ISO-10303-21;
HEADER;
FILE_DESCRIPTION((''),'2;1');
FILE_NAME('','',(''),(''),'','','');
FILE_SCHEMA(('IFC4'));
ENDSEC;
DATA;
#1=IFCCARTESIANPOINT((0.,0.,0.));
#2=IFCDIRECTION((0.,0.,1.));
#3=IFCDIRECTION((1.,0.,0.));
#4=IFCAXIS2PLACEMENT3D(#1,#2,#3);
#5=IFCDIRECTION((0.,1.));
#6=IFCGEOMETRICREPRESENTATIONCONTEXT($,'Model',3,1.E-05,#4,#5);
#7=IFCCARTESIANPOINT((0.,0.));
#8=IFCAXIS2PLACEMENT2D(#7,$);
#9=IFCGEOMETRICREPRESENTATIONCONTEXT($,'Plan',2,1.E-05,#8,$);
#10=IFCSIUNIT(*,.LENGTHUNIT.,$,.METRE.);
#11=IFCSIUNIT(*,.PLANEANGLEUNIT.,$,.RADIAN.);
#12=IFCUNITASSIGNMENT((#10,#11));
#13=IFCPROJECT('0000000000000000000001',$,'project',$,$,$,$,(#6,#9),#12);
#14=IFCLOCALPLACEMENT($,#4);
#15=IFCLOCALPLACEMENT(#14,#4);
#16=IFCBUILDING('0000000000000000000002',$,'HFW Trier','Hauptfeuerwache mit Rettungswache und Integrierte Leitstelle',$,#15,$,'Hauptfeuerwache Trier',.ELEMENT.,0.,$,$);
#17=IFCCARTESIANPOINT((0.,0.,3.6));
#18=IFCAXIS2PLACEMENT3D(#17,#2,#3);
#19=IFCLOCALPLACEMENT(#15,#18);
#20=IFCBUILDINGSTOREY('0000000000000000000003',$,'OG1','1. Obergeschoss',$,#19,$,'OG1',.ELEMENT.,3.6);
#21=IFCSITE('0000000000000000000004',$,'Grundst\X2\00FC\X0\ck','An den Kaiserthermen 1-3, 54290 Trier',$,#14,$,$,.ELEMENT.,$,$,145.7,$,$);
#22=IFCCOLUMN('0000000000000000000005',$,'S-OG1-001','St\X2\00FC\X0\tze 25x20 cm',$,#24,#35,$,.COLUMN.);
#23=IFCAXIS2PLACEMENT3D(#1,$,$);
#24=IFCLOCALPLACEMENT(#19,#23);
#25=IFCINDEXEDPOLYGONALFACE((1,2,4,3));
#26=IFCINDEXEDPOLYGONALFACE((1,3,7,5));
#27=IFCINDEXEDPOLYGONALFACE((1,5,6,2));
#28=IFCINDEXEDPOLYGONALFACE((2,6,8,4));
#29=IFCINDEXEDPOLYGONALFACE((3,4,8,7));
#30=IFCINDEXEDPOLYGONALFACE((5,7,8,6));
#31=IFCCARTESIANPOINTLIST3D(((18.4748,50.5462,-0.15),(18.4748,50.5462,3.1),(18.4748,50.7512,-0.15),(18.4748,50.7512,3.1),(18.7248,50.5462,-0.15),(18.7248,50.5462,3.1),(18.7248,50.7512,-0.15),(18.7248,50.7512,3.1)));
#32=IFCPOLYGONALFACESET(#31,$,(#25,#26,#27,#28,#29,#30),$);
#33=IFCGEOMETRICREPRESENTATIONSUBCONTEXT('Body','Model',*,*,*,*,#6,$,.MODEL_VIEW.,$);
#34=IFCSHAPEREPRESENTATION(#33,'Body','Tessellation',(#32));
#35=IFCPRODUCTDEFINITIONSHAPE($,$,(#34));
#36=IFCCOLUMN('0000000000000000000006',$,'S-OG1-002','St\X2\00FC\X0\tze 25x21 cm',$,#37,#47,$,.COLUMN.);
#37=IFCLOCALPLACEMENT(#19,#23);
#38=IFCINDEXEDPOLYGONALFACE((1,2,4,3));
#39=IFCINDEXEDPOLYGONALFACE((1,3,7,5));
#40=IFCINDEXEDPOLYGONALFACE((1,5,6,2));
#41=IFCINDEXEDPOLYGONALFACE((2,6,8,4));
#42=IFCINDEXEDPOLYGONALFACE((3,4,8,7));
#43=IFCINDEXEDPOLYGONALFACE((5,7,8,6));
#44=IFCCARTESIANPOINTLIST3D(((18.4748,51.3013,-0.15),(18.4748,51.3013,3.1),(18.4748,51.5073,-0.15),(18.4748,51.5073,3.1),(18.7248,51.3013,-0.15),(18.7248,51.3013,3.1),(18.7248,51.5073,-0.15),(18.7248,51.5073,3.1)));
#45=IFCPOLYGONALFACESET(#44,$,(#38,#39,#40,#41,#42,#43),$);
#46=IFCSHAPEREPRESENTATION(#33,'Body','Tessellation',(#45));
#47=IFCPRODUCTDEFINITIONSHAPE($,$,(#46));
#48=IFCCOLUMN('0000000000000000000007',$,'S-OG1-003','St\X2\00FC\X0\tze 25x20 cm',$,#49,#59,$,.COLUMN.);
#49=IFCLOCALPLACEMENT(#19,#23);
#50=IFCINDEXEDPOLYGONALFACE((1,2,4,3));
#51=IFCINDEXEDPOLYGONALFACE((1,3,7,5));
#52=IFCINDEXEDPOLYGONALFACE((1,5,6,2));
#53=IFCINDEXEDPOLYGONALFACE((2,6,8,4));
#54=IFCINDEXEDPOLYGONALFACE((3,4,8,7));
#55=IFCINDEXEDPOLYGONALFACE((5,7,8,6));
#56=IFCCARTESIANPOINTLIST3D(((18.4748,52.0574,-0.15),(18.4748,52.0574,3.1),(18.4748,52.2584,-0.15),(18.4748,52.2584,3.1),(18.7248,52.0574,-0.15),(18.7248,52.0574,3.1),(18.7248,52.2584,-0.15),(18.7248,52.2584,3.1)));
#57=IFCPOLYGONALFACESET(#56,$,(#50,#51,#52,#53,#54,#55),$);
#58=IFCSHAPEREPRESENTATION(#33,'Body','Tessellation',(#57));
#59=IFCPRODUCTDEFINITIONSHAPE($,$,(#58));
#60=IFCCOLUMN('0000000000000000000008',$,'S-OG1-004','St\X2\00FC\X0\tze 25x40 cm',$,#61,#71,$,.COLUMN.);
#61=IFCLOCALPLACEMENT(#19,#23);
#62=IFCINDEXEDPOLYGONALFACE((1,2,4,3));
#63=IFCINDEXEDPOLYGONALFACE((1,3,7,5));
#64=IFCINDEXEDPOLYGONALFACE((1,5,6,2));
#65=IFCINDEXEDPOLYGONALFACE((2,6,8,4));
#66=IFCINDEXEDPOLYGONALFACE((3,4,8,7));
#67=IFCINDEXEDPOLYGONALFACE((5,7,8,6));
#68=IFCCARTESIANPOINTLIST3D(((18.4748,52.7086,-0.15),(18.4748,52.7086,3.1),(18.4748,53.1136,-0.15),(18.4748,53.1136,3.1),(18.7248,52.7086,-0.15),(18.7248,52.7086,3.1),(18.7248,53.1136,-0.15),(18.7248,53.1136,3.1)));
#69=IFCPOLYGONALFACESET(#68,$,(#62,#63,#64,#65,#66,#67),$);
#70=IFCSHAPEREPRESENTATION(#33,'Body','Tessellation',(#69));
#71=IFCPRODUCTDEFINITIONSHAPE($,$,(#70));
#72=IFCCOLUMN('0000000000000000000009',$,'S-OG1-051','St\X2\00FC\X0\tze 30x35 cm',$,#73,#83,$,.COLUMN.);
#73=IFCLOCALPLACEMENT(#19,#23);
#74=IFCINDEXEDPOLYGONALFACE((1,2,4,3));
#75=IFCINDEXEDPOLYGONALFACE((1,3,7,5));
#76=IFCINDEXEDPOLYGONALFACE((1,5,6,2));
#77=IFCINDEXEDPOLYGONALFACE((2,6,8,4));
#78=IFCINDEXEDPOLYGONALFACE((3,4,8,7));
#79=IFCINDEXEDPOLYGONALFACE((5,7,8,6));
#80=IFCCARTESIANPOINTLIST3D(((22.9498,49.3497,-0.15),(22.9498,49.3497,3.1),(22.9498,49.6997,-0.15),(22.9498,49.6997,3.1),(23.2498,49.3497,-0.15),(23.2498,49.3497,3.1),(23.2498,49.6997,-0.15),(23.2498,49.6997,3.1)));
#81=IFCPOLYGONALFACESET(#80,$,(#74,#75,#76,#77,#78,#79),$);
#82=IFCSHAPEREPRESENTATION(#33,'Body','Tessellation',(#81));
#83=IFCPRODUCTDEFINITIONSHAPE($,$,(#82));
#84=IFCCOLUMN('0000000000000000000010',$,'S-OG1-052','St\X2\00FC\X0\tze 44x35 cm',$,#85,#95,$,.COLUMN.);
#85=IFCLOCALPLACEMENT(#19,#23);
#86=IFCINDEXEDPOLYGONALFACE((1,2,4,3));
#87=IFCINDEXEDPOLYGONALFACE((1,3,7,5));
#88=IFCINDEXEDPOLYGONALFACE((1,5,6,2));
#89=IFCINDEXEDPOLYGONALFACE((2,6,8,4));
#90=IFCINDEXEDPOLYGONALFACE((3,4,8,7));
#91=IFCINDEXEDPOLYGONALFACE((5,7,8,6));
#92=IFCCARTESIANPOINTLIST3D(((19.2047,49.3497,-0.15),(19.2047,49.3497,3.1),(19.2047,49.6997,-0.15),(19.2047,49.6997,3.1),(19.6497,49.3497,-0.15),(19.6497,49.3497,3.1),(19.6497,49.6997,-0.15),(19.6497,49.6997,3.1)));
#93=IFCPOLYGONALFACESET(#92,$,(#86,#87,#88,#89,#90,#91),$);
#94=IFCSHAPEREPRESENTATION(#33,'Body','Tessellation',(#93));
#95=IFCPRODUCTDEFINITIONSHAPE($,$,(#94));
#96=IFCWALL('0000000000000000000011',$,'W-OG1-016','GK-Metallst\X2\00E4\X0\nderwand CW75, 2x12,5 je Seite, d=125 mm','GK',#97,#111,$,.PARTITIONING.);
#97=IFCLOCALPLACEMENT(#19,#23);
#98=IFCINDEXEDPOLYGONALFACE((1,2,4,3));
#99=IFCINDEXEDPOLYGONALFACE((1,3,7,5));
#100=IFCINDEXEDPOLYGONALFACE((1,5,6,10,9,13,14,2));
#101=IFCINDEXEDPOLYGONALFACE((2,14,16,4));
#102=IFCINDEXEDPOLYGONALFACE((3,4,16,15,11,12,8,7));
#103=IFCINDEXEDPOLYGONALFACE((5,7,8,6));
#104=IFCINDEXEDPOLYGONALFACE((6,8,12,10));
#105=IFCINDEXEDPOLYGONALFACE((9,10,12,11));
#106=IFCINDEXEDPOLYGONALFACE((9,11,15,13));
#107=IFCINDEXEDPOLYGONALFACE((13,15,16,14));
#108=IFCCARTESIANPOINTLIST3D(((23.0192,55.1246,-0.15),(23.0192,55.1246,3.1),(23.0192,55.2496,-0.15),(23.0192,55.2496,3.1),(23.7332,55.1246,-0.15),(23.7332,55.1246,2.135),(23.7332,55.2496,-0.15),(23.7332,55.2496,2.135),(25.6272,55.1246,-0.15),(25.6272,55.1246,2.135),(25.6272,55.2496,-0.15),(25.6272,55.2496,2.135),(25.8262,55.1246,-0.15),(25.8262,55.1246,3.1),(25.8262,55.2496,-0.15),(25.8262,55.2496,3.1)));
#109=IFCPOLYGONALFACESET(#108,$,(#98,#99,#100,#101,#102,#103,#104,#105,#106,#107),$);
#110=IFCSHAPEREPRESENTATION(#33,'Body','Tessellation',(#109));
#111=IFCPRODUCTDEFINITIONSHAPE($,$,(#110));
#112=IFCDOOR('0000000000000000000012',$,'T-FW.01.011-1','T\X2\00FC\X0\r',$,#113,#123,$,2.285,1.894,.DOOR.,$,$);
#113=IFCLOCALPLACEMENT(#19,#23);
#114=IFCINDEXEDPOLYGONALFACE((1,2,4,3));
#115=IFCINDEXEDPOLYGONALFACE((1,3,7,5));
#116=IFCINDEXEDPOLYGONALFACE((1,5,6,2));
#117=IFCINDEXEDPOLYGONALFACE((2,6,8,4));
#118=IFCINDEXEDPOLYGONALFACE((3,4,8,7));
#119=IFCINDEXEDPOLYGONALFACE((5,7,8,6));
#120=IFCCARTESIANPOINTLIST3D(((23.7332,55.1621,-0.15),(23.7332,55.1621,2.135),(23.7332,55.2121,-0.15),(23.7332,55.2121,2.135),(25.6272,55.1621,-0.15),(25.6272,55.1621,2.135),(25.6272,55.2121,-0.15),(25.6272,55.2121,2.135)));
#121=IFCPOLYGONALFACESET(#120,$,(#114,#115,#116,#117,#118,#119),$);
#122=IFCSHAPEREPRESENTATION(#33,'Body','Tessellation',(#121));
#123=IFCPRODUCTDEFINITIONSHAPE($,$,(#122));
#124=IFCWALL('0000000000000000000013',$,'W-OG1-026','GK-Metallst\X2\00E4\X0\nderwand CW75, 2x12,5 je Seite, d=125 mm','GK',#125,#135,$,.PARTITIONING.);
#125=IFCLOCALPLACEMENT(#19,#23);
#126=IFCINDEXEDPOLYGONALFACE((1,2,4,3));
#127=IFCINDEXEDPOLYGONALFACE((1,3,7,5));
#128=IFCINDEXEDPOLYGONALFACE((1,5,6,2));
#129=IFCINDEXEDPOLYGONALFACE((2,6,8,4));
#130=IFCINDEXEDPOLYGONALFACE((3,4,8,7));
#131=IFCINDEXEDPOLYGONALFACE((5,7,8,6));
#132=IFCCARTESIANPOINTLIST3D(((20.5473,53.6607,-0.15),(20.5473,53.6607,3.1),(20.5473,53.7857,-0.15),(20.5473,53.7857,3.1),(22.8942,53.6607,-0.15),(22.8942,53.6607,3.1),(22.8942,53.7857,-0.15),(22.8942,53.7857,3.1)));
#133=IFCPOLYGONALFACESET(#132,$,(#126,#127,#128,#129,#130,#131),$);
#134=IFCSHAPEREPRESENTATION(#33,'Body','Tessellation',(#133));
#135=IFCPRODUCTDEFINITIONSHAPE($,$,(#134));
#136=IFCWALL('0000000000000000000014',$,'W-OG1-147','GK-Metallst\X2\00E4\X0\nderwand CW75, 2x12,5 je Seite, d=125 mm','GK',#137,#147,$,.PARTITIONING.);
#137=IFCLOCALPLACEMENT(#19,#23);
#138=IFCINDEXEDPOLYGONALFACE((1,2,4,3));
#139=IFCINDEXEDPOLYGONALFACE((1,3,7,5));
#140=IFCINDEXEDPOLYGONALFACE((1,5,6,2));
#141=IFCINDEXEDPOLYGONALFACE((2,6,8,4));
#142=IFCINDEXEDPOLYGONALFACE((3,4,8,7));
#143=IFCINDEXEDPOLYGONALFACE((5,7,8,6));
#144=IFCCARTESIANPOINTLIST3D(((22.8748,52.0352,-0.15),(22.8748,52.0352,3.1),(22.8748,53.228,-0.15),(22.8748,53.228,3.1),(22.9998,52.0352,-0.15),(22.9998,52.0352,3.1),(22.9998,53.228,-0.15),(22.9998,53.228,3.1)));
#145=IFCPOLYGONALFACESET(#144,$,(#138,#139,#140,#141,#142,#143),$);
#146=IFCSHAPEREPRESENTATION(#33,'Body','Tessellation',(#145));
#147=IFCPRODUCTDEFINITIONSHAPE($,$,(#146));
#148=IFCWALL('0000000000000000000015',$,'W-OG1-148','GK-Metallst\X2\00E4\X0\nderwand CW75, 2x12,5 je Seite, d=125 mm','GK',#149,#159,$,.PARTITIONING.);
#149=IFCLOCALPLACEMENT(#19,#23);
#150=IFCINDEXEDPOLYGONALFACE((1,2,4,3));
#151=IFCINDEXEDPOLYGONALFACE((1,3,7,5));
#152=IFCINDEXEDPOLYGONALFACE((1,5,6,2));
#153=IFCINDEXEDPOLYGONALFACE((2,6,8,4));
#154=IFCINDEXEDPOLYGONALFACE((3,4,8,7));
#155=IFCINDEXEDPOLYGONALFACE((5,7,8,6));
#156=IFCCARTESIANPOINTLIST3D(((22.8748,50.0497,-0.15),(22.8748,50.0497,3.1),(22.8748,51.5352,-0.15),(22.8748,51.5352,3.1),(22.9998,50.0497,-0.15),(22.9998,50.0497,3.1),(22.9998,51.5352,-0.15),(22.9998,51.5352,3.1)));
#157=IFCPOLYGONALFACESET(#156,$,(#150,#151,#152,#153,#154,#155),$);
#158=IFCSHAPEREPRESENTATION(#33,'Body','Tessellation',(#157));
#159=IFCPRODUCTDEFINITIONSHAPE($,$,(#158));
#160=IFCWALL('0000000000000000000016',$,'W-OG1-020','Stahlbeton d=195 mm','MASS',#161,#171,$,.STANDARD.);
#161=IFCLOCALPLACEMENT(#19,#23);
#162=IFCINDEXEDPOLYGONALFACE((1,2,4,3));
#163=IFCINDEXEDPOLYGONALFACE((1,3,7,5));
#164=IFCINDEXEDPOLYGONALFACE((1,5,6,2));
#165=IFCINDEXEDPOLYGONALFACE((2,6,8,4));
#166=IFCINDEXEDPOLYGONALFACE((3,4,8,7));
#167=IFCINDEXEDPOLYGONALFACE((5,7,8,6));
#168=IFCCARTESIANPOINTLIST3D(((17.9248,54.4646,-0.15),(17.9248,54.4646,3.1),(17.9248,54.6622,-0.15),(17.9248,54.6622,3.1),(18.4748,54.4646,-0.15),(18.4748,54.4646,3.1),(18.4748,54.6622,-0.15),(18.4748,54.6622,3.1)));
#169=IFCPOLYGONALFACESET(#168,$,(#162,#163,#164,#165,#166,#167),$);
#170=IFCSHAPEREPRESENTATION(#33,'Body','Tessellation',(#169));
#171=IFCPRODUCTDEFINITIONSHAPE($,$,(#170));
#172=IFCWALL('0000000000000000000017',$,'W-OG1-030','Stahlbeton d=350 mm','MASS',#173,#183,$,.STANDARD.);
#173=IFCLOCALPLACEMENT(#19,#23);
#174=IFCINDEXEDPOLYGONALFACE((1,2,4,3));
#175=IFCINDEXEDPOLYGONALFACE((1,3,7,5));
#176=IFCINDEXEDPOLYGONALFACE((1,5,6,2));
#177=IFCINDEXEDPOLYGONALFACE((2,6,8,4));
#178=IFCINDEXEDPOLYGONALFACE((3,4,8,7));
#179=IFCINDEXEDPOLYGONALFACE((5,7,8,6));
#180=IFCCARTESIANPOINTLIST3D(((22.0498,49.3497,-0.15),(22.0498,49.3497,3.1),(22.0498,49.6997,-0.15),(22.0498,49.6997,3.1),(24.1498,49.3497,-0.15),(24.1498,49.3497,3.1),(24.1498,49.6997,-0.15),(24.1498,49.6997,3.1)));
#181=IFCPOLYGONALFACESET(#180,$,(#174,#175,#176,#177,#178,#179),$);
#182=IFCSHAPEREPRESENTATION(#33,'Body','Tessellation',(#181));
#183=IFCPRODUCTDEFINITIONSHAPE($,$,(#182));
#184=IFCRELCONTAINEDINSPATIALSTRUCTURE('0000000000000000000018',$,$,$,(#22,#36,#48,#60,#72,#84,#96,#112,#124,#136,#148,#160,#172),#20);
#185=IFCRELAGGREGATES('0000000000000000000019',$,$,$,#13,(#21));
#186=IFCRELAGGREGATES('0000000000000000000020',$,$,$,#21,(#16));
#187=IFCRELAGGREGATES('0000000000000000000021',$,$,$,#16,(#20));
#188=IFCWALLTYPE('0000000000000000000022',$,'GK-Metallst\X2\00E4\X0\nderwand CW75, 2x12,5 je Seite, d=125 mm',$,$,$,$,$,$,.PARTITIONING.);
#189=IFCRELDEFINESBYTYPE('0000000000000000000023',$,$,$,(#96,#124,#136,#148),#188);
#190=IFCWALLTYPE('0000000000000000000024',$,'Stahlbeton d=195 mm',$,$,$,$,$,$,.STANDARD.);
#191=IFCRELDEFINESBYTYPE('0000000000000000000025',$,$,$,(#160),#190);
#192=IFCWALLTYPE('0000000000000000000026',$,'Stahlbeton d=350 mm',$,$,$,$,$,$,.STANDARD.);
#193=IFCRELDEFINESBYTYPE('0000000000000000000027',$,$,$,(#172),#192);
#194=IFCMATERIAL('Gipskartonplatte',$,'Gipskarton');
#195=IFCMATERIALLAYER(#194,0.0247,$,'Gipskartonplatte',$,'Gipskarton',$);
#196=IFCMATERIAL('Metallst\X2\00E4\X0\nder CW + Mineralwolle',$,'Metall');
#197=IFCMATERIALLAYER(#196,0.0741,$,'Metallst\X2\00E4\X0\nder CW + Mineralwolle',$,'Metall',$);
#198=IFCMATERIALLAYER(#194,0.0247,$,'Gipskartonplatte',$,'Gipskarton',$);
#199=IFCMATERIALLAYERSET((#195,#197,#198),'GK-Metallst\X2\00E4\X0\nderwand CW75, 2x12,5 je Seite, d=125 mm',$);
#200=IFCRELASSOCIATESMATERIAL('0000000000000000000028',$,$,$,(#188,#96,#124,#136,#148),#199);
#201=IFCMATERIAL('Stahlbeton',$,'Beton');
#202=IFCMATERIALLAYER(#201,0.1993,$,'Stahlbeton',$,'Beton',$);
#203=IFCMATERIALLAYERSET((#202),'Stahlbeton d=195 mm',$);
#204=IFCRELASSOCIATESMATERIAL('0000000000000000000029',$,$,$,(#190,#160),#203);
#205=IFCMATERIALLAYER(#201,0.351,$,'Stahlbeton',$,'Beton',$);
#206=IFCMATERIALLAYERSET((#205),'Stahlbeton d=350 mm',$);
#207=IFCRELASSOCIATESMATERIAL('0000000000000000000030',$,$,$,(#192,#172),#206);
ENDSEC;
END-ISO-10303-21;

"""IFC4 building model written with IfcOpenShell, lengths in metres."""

from ifc_helpers import new_model, si_unit, direction, frame, frame_2d, origin_with_axes, origin_2d, place, context, subcontext, project, spatial, rectangle, extrude, material, layer, layer_set, layer_usage, type_object, element, fill, save


model = new_model("IFC4")

# Units and contexts
model_context = context("Model", 3, precision=1e-05, world=origin_with_axes(), true_north=direction((0.0, 1.0)))
plan_context = context("Plan", 2, precision=1e-05, world=origin_2d())
body_context = subcontext(model_context, "Body", "Model", "MODEL_VIEW")
ifc_project = project(units=[si_unit("LENGTHUNIT", "METRE"), si_unit("PLANEANGLEUNIT", "RADIAN")], contexts=[model_context, plan_context])

# Site, building, storey
site_placement = place(None, origin_with_axes())
site = spatial("IfcSite", under=ifc_project, at=site_placement, Name="Grundstück", Description="An den Kaiserthermen 1-3, 54290 Trier", CompositionType="ELEMENT", RefElevation=145.7)
building_placement = place(site_placement, origin_with_axes())
building = spatial("IfcBuilding", under=site, at=building_placement, Name="HFW Trier", Description="Hauptfeuerwache mit Rettungswache und Integrierte Leitstelle", LongName="Hauptfeuerwache Trier", CompositionType="ELEMENT", ElevationOfRefHeight=0.0)
storey_placement = place(building_placement, frame((0.0, 0.0, 3.6), z_axis=(0.0, 0.0, 1.0), x_axis=(1.0, 0.0, 0.0)))
storey = spatial("IfcBuildingStorey", under=building, at=storey_placement, Name="OG1", Description="1. Obergeschoss", LongName="OG1", CompositionType="ELEMENT", Elevation=3.6)

# Columns
column_1_placement = place(storey_placement, frame((18.4748, 50.6487, -0.15), z_axis=(0.0, 0.0, 1.0), x_axis=(1.0, 0.0, 0.0)))
element("IfcColumn", 1, at=column_1_placement, inside=storey, Name="S-OG1-001", Description="Stütze 25x20 cm", PredefinedType="COLUMN", context=body_context, shape_type="SweptSolid", body=[
    extrude(rectangle(XDim=0.25, YDim=0.205, at=frame_2d((0.125, 0.0))), origin_with_axes(), (0.0, 0.0, 1.0), 3.25),
])
column_2_placement = place(storey_placement, frame((18.4748, 51.4043, -0.15), z_axis=(0.0, 0.0, 1.0), x_axis=(1.0, 0.0, 0.0)))
element("IfcColumn", 2, at=column_2_placement, inside=storey, Name="S-OG1-002", Description="Stütze 25x21 cm", PredefinedType="COLUMN", context=body_context, shape_type="SweptSolid", body=[
    extrude(rectangle(XDim=0.25, YDim=0.206, at=frame_2d((0.125, 0.0))), origin_with_axes(), (0.0, 0.0, 1.0), 3.25),
])
column_3_placement = place(storey_placement, frame((18.4748, 52.1579, -0.15), z_axis=(0.0, 0.0, 1.0), x_axis=(1.0, 0.0, 0.0)))
element("IfcColumn", 3, at=column_3_placement, inside=storey, Name="S-OG1-003", Description="Stütze 25x20 cm", PredefinedType="COLUMN", context=body_context, shape_type="SweptSolid", body=[
    extrude(rectangle(XDim=0.25, YDim=0.201, at=frame_2d((0.125, 0.0))), origin_with_axes(), (0.0, 0.0, 1.0), 3.25),
])
column_4_placement = place(storey_placement, frame((18.4748, 52.9111, -0.15), z_axis=(0.0, 0.0, 1.0), x_axis=(1.0, 0.0, 0.0)))
element("IfcColumn", 4, at=column_4_placement, inside=storey, Name="S-OG1-004", Description="Stütze 25x40 cm", PredefinedType="COLUMN", context=body_context, shape_type="SweptSolid", body=[
    extrude(rectangle(XDim=0.25, YDim=0.405, at=frame_2d((0.125, 0.0))), origin_with_axes(), (0.0, 0.0, 1.0), 3.25),
])
column_5_placement = place(storey_placement, frame((22.9498, 49.5247, -0.15), z_axis=(0.0, 0.0, 1.0), x_axis=(1.0, 0.0, 0.0)))
element("IfcColumn", 5, at=column_5_placement, inside=storey, Name="S-OG1-051", Description="Stütze 30x35 cm", PredefinedType="COLUMN", context=body_context, shape_type="SweptSolid", body=[
    extrude(rectangle(XDim=0.3, YDim=0.35, at=frame_2d((0.15, 0.0))), origin_with_axes(), (0.0, 0.0, 1.0), 3.25),
])
column_6_placement = place(storey_placement, frame((19.2047, 49.5247, -0.15), z_axis=(0.0, 0.0, 1.0), x_axis=(1.0, 0.0, 0.0)))
element("IfcColumn", 6, at=column_6_placement, inside=storey, Name="S-OG1-052", Description="Stütze 44x35 cm", PredefinedType="COLUMN", context=body_context, shape_type="SweptSolid", body=[
    extrude(rectangle(XDim=0.445, YDim=0.35, at=frame_2d((0.2225, 0.0))), origin_with_axes(), (0.0, 0.0, 1.0), 3.25),
])

# Wall, opening, door
ifc_material_1 = material(Name="Gipskartonplatte", Category="Gipskarton")
ifc_layer_1 = layer(ifc_material_1, 0.0247, Name="Gipskartonplatte", Category="Gipskarton")
ifc_material_2 = material(Name="Metallständer CW + Mineralwolle", Category="Metall")
ifc_layer_2 = layer(ifc_material_2, 0.0741, Name="Metallständer CW + Mineralwolle", Category="Metall")
ifc_layer_3 = layer(ifc_material_1, 0.0247, Name="Gipskartonplatte", Category="Gipskarton")
ifc_layer_set_1 = layer_set([ifc_layer_1, ifc_layer_2, ifc_layer_3], Name="GK-Metallständerwand CW75, 2x12,5 je Seite, d=125 mm")
ifc_layer_usage_1 = layer_usage(ifc_layer_set_1, "AXIS2", "POSITIVE", -0.0625)
wall_type_1 = type_object("IfcWallType", Name="GK-Metallständerwand CW75, 2x12,5 je Seite, d=125 mm", PredefinedType="PARTITIONING", material=ifc_layer_set_1)
wall_1_placement = place(storey_placement, frame((23.0192, 55.1871, -0.15), z_axis=(0.0, 0.0, 1.0), x_axis=(1.0, 0.0, 0.0)))
wall_1 = element("IfcWall", 7, at=wall_1_placement, inside=storey, type_object=wall_type_1, material=ifc_layer_usage_1, Name="W-OG1-016", Description="GK-Metallständerwand CW75, 2x12,5 je Seite, d=125 mm", ObjectType="GK", PredefinedType="PARTITIONING", context=body_context, shape_type="SweptSolid", body=[
    extrude(rectangle(XDim=2.807, YDim=0.125, at=frame_2d((1.4035, 0.0))), origin_with_axes(), (0.0, 0.0, 1.0), 3.25),
])
opening_1_placement = place(wall_1_placement, frame((0.714, 0.0, 0.0), z_axis=(0.0, 0.0, 1.0), x_axis=(1.0, 0.0, 0.0)))
opening_1 = element("IfcOpeningElement", 8, at=opening_1_placement, cuts=wall_1, PredefinedType="OPENING", context=body_context, shape_type="SweptSolid", body=[
    extrude(rectangle(XDim=1.894, YDim=0.225, at=frame_2d((0.947, 0.0))), origin_with_axes(), (0.0, 0.0, 1.0), 2.285),
])
door_1_placement = place(wall_1_placement, frame((0.714, 0.0, 0.0), z_axis=(0.0, 0.0, 1.0), x_axis=(1.0, 0.0, 0.0)))
door_1 = element("IfcDoor", 9, at=door_1_placement, inside=storey, Name="T-FW.01.011-1", Description="Tür", OverallHeight=2.285, OverallWidth=1.894, PredefinedType="DOOR", context=body_context, shape_type="SweptSolid", body=[
    extrude(rectangle(XDim=1.894, YDim=0.05, at=frame_2d((0.947, 0.0))), origin_with_axes(), (0.0, 0.0, 1.0), 2.285),
])
fill(opening_1, door_1)

# Walls
ifc_layer_usage_2 = layer_usage(ifc_layer_set_1, "AXIS2", "POSITIVE", -0.0625)
wall_2_placement = place(storey_placement, frame((20.5473, 53.7232, -0.15), z_axis=(0.0, 0.0, 1.0), x_axis=(1.0, 0.0, 0.0)))
element("IfcWall", 10, at=wall_2_placement, inside=storey, type_object=wall_type_1, material=ifc_layer_usage_2, Name="W-OG1-026", Description="GK-Metallständerwand CW75, 2x12,5 je Seite, d=125 mm", ObjectType="GK", PredefinedType="PARTITIONING", context=body_context, shape_type="SweptSolid", body=[
    extrude(rectangle(XDim=2.3469, YDim=0.125, at=frame_2d((1.1735, 0.0))), origin_with_axes(), (0.0, 0.0, 1.0), 3.25),
])
ifc_layer_usage_3 = layer_usage(ifc_layer_set_1, "AXIS2", "POSITIVE", -0.0625)
wall_3_placement = place(storey_placement, frame((22.9373, 53.228, -0.15), z_axis=(0.0, 0.0, 1.0), x_axis=(0.0, -1.0, 0.0)))
element("IfcWall", 11, at=wall_3_placement, inside=storey, type_object=wall_type_1, material=ifc_layer_usage_3, Name="W-OG1-147", Description="GK-Metallständerwand CW75, 2x12,5 je Seite, d=125 mm", ObjectType="GK", PredefinedType="PARTITIONING", context=body_context, shape_type="SweptSolid", body=[
    extrude(rectangle(XDim=1.1928, YDim=0.125, at=frame_2d((0.5964, 0.0))), origin_with_axes(), (0.0, 0.0, 1.0), 3.25),
])
ifc_layer_usage_4 = layer_usage(ifc_layer_set_1, "AXIS2", "POSITIVE", -0.0625)
wall_4_placement = place(storey_placement, frame((22.9373, 51.5352, -0.15), z_axis=(0.0, 0.0, 1.0), x_axis=(0.0, -1.0, 0.0)))
element("IfcWall", 12, at=wall_4_placement, inside=storey, type_object=wall_type_1, material=ifc_layer_usage_4, Name="W-OG1-148", Description="GK-Metallständerwand CW75, 2x12,5 je Seite, d=125 mm", ObjectType="GK", PredefinedType="PARTITIONING", context=body_context, shape_type="SweptSolid", body=[
    extrude(rectangle(XDim=1.4855, YDim=0.125, at=frame_2d((0.7428, 0.0))), origin_with_axes(), (0.0, 0.0, 1.0), 3.25),
])
ifc_material_3 = material(Name="Stahlbeton", Category="Beton")
ifc_layer_4 = layer(ifc_material_3, 0.1993, Name="Stahlbeton", Category="Beton")
ifc_layer_set_2 = layer_set([ifc_layer_4], Name="Stahlbeton d=195 mm")
ifc_layer_usage_5 = layer_usage(ifc_layer_set_2, "AXIS2", "POSITIVE", -0.0988)
wall_type_2 = type_object("IfcWallType", Name="Stahlbeton d=195 mm", PredefinedType="STANDARD", material=ifc_layer_set_2)
wall_5_placement = place(storey_placement, frame((17.9248, 54.5634, -0.15), z_axis=(0.0, 0.0, 1.0), x_axis=(1.0, 0.0, 0.0)))
element("IfcWall", 13, at=wall_5_placement, inside=storey, type_object=wall_type_2, material=ifc_layer_usage_5, Name="W-OG1-020", Description="Stahlbeton d=195 mm", ObjectType="MASS", PredefinedType="STANDARD", context=body_context, shape_type="SweptSolid", body=[
    extrude(rectangle(XDim=0.55, YDim=0.1975, at=frame_2d((0.275, 0.0))), origin_with_axes(), (0.0, 0.0, 1.0), 3.25),
])
ifc_layer_5 = layer(ifc_material_3, 0.351, Name="Stahlbeton", Category="Beton")
ifc_layer_set_3 = layer_set([ifc_layer_5], Name="Stahlbeton d=350 mm")
ifc_layer_usage_6 = layer_usage(ifc_layer_set_3, "AXIS2", "POSITIVE", -0.175)
wall_type_3 = type_object("IfcWallType", Name="Stahlbeton d=350 mm", PredefinedType="STANDARD", material=ifc_layer_set_3)
wall_6_placement = place(storey_placement, frame((22.0498, 49.5247, -0.15), z_axis=(0.0, 0.0, 1.0), x_axis=(1.0, 0.0, 0.0)))
element("IfcWall", 14, at=wall_6_placement, inside=storey, type_object=wall_type_3, material=ifc_layer_usage_6, Name="W-OG1-030", Description="Stahlbeton d=350 mm", ObjectType="MASS", PredefinedType="STANDARD", context=body_context, shape_type="SweptSolid", body=[
    extrude(rectangle(XDim=2.1, YDim=0.35, at=frame_2d((1.05, 0.0))), origin_with_axes(), (0.0, 0.0, 1.0), 3.25),
])

save(model, "model.ifc")
